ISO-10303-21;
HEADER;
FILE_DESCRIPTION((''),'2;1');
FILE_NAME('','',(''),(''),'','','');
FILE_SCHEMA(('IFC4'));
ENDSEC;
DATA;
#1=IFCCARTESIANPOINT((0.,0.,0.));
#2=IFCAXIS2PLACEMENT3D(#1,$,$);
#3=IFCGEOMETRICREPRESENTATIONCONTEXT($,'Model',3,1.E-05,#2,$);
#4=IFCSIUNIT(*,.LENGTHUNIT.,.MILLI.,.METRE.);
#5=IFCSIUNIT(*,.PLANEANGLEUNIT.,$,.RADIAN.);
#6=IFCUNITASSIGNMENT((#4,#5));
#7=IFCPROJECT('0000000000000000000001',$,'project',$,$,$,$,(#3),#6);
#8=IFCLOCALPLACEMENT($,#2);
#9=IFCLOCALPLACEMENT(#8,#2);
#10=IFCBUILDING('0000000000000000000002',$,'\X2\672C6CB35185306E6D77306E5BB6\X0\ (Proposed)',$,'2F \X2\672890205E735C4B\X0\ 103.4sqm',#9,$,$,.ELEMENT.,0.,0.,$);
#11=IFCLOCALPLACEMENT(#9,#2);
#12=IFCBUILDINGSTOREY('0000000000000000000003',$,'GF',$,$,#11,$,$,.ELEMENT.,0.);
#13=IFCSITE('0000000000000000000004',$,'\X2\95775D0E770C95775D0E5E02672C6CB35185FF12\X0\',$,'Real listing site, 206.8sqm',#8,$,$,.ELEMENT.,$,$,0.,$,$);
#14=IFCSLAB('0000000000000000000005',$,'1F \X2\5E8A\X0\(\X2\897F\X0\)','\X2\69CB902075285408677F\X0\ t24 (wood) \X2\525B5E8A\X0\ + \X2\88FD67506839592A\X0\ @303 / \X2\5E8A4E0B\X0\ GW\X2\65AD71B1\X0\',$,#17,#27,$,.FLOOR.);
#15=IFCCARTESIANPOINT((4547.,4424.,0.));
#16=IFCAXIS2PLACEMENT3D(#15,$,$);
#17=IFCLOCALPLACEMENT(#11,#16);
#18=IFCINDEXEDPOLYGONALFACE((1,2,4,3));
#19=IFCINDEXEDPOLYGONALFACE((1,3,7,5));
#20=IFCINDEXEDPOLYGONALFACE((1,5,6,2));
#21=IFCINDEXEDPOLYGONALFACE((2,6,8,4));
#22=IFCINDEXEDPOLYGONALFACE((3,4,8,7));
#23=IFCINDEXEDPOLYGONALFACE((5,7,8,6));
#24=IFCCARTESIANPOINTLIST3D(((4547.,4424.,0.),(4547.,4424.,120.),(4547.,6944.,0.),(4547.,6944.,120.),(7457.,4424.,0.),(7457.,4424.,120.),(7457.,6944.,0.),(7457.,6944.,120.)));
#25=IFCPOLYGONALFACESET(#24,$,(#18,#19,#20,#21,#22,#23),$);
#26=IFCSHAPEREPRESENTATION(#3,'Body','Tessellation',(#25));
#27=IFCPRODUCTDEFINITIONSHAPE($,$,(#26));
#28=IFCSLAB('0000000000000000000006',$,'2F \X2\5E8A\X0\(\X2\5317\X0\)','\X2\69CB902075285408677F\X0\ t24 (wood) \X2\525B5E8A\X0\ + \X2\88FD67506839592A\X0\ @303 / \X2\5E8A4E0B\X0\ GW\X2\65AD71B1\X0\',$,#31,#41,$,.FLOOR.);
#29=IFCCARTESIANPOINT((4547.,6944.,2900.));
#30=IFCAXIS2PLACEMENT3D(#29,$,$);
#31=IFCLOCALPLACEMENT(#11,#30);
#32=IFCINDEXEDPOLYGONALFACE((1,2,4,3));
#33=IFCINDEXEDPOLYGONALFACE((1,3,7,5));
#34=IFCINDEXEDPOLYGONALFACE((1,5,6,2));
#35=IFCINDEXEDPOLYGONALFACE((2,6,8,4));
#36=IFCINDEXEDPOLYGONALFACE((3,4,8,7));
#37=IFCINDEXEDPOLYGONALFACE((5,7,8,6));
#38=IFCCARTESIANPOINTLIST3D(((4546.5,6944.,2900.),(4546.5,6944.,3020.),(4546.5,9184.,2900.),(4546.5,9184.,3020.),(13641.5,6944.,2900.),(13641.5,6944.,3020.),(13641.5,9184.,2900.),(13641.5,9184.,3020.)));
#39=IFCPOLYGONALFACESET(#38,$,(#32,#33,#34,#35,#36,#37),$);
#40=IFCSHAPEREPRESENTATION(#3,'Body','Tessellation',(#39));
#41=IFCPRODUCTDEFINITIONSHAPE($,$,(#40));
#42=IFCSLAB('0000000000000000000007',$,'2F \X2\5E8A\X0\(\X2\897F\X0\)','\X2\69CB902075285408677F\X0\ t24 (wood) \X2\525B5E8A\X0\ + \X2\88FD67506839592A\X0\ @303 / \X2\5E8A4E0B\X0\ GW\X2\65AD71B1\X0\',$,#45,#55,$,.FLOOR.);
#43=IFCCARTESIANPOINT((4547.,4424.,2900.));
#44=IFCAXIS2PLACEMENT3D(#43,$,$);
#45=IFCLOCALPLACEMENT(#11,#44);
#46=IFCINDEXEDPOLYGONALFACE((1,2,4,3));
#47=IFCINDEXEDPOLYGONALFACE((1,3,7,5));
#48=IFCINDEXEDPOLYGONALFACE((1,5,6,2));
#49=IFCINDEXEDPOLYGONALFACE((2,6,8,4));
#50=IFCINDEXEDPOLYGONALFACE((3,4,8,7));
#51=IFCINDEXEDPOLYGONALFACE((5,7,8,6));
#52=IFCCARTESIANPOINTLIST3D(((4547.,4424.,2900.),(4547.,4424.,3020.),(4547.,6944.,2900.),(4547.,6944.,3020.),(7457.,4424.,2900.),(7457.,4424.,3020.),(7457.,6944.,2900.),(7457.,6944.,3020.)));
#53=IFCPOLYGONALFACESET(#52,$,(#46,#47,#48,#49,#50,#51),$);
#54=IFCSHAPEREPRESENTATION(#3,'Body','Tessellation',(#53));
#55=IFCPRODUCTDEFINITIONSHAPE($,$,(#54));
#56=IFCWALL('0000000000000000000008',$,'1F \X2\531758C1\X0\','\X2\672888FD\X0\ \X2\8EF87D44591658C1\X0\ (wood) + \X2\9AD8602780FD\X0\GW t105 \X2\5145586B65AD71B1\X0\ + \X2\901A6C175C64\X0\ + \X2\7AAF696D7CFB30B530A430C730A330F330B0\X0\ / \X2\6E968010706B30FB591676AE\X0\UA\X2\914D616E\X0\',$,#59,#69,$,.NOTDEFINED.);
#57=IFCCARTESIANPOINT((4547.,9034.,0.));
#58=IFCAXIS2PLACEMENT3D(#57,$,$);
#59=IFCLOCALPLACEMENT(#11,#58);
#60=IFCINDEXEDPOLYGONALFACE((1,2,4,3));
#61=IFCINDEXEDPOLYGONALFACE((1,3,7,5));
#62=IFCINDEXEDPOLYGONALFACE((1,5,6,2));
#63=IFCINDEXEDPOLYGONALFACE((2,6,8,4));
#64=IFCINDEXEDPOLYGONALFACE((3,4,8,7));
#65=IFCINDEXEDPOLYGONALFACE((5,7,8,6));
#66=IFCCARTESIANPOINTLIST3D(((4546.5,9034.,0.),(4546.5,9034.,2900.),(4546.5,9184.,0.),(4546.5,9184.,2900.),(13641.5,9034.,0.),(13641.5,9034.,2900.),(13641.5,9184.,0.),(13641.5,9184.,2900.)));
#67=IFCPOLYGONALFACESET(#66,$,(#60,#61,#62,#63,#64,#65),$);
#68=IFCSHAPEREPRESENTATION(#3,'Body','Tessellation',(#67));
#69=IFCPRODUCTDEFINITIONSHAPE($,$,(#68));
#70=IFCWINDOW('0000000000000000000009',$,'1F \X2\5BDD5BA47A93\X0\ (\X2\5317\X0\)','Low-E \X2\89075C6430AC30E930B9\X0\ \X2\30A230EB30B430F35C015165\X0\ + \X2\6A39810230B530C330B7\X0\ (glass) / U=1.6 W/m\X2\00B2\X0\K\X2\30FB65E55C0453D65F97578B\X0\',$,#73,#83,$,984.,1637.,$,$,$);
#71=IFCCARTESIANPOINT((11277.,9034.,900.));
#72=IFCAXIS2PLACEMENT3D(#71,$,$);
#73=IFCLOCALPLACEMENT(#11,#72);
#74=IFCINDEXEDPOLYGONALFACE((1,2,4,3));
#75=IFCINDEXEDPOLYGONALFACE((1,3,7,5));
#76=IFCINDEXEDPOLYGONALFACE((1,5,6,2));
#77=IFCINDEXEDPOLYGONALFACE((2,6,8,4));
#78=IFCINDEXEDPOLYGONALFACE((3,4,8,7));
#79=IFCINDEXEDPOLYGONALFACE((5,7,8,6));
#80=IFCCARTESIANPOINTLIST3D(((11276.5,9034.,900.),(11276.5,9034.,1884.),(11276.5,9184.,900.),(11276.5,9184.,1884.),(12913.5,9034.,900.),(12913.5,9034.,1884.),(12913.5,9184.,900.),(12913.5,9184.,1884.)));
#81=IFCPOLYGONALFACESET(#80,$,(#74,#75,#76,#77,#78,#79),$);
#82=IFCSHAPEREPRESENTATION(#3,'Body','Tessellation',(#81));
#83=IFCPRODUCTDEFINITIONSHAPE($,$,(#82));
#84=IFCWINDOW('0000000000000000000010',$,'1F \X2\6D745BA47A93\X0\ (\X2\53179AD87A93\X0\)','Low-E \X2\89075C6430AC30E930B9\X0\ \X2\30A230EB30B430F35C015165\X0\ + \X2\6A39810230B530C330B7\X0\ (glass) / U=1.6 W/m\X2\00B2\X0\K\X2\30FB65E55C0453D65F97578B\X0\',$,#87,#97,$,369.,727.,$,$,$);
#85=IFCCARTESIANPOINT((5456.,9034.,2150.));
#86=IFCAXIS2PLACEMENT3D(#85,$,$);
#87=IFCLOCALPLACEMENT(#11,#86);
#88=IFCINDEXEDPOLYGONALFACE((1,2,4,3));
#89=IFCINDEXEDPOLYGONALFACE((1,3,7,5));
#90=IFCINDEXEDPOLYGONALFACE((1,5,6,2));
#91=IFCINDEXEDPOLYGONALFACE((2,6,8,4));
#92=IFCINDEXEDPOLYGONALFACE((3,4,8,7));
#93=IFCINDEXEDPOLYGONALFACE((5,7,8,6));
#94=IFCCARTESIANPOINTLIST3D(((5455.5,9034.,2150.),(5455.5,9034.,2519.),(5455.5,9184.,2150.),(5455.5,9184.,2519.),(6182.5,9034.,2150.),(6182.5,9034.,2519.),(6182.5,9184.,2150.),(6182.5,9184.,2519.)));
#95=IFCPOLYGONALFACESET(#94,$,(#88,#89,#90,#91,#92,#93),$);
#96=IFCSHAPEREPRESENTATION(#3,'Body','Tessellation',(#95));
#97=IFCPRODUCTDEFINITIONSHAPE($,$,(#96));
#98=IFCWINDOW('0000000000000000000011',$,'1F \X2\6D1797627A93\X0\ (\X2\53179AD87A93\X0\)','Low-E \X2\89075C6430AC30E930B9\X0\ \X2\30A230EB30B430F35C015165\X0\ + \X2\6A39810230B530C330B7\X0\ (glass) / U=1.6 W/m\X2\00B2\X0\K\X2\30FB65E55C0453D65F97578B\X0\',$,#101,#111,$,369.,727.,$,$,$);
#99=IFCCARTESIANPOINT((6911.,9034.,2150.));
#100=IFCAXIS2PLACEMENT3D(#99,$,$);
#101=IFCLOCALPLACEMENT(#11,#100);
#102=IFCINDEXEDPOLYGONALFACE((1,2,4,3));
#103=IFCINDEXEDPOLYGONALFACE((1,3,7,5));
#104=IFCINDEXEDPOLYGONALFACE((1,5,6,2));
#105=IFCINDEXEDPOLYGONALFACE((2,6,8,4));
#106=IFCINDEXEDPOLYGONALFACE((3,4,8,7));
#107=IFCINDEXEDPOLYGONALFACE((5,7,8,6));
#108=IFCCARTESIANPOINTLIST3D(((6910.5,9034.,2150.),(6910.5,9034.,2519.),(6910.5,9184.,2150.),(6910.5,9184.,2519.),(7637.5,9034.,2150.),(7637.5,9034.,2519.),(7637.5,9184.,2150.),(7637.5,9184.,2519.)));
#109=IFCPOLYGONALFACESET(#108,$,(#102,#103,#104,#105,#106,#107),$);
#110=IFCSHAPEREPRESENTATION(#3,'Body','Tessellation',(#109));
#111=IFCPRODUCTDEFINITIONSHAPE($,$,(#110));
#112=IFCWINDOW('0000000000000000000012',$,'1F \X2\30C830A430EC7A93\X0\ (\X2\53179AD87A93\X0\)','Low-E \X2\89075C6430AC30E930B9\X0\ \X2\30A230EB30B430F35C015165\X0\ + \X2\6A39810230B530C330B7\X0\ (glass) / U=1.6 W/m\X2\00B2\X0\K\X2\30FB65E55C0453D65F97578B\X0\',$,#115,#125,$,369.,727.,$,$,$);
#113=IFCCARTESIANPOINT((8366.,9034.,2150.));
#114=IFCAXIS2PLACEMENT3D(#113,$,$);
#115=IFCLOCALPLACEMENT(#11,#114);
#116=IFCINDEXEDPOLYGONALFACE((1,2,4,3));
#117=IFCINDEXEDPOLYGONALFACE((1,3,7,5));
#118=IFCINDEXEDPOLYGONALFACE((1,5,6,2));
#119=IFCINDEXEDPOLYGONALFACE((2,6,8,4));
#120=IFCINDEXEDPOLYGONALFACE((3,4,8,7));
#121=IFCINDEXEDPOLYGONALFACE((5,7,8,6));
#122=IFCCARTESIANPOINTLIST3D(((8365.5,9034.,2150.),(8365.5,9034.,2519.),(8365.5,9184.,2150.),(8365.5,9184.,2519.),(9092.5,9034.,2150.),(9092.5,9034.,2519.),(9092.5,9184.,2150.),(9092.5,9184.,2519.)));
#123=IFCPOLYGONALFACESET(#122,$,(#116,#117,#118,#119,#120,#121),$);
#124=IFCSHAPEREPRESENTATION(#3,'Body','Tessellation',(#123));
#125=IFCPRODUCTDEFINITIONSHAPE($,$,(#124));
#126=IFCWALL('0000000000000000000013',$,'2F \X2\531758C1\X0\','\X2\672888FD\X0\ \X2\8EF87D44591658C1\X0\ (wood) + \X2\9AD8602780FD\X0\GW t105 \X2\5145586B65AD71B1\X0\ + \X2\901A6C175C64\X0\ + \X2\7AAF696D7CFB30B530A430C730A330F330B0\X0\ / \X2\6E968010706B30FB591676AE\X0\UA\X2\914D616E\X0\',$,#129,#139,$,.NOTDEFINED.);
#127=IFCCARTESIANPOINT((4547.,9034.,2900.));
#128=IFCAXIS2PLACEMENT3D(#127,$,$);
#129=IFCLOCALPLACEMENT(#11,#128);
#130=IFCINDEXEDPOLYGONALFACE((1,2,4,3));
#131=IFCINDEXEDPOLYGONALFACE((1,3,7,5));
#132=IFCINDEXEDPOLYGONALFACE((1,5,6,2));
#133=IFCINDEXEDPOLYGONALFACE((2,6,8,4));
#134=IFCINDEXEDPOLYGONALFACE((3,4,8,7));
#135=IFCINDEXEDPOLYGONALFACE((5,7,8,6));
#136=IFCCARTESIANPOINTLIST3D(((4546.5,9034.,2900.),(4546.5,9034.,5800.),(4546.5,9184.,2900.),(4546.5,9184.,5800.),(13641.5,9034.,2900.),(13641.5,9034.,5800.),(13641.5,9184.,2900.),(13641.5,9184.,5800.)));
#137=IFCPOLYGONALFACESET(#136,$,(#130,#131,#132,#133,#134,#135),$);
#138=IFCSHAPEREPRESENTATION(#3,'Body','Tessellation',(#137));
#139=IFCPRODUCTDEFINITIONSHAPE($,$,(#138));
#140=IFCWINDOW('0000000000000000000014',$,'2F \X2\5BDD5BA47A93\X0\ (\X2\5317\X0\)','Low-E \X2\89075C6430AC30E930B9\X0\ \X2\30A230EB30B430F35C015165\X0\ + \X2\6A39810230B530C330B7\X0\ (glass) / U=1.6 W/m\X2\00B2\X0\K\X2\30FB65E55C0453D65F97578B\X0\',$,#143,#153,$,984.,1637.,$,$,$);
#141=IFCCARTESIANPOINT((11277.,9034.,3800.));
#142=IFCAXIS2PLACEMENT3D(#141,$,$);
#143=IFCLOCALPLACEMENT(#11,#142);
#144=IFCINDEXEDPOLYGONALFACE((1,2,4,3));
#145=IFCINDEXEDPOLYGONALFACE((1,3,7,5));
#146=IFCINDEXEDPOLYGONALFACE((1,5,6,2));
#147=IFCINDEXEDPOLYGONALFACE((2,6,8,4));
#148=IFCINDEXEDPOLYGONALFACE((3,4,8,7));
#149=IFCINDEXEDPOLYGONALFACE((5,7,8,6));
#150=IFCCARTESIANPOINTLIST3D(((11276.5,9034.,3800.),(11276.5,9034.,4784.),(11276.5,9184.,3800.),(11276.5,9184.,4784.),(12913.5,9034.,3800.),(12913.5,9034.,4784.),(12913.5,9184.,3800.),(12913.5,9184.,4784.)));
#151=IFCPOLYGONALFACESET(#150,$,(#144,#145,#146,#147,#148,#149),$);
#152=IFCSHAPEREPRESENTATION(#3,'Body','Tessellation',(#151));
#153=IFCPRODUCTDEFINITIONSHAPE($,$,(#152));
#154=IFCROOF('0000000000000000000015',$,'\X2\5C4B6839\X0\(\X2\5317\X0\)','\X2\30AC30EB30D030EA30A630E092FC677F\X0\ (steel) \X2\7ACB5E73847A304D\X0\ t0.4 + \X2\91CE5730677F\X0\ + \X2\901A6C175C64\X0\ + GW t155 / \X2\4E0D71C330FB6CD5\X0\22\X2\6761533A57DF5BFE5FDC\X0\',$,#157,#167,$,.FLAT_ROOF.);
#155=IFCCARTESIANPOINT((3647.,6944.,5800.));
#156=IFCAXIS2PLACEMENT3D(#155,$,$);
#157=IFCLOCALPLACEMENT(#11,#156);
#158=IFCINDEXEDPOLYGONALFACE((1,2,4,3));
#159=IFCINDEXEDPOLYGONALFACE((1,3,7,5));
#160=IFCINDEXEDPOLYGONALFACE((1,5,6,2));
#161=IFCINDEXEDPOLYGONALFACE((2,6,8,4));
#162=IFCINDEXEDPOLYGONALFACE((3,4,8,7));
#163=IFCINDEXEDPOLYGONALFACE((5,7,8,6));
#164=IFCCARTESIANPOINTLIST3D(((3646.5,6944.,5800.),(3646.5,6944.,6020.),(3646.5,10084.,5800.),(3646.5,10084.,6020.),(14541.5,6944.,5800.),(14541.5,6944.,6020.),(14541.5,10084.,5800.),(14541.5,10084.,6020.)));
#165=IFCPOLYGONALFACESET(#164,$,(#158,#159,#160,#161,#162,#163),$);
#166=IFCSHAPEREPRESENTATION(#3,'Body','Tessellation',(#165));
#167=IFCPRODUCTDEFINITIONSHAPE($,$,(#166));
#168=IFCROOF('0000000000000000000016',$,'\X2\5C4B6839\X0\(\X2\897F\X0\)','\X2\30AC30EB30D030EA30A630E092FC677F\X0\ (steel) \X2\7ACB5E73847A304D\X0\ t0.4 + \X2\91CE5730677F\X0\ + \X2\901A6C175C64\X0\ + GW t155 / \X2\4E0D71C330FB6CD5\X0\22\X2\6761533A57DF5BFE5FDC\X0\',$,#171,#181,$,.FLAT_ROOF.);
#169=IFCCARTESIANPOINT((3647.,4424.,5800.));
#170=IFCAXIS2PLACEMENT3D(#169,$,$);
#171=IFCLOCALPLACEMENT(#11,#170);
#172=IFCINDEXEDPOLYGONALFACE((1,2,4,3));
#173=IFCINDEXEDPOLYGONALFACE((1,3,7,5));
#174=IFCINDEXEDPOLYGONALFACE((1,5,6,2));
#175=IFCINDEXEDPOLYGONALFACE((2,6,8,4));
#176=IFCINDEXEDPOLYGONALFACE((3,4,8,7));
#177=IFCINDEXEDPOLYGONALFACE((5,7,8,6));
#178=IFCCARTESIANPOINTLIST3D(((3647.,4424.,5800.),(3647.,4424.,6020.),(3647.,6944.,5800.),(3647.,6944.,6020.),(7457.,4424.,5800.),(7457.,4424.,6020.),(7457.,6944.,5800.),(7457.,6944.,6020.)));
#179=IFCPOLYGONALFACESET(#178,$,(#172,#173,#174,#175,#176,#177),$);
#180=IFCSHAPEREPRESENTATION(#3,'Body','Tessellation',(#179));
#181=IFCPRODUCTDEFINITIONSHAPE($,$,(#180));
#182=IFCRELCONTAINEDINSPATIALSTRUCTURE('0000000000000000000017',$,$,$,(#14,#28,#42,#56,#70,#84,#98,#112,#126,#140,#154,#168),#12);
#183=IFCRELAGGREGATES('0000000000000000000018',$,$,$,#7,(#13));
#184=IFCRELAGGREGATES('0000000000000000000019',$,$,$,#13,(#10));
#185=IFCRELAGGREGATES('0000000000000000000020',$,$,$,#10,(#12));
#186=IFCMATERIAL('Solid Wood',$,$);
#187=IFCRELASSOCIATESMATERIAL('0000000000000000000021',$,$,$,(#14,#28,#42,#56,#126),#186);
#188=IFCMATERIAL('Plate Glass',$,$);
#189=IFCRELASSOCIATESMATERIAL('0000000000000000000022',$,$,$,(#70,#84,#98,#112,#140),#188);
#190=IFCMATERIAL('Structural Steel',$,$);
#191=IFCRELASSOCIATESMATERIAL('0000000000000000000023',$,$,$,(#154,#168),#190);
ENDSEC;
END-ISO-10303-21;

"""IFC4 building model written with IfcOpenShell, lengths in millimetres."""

from ifc_helpers import new_model, si_unit, frame, frame_2d, origin, place, context, project, spatial, rectangle, extrude, material, element, fill, save


model = new_model("IFC4")

# Units and contexts
model_context = context("Model", 3, precision=1e-05, world=origin())
ifc_project = project(units=[si_unit("LENGTHUNIT", "METRE", prefix="MILLI"), si_unit("PLANEANGLEUNIT", "RADIAN")], contexts=[model_context])

# Site, building, storey
site_placement = place(None, origin())
site = spatial("IfcSite", under=ifc_project, at=site_placement, Name="長崎県長崎市本河内２", ObjectType="Real listing site, 206.8sqm", CompositionType="ELEMENT", RefElevation=0.0)
building_placement = place(site_placement, origin())
building = spatial("IfcBuilding", under=site, at=building_placement, Name="本河内の海の家 (Proposed)", ObjectType="2F 木造平屋 103.4sqm", CompositionType="ELEMENT", ElevationOfRefHeight=0.0, ElevationOfTerrain=0.0)
storey_placement = place(building_placement, origin())
storey = spatial("IfcBuildingStorey", under=building, at=storey_placement, Name="GF", CompositionType="ELEMENT", Elevation=0.0)

# Slabs
ifc_material_1 = material(Name="Solid Wood")
slab_1_placement = place(storey_placement, frame((4547.0, 4424.0, 0.0)))
element("IfcSlab", 1, at=slab_1_placement, inside=storey, material=ifc_material_1, Name="1F 床(西)", Description="構造用合板 t24 (wood) 剛床 + 製材根太 @303 / 床下 GW断熱", PredefinedType="FLOOR", context=model_context, shape_type="SweptSolid", body=[
    extrude(rectangle(XDim=2910.0, YDim=2520.0, at=frame_2d((1455.0, 1260.0))), frame((4547.0, 4424.0, 0.0)), (0.0, 0.0, 1.0), 120.0),
])
slab_2_placement = place(storey_placement, frame((4547.0, 6944.0, 2900.0)))
element("IfcSlab", 2, at=slab_2_placement, inside=storey, material=ifc_material_1, Name="2F 床(北)", Description="構造用合板 t24 (wood) 剛床 + 製材根太 @303 / 床下 GW断熱", PredefinedType="FLOOR", context=model_context, shape_type="SweptSolid", body=[
    extrude(rectangle(XDim=9095.0, YDim=2240.0, at=frame_2d((4547.0, 1120.0))), frame((4547.0, 6944.0, 2900.0)), (0.0, 0.0, 1.0), 120.0),
])
slab_3_placement = place(storey_placement, frame((4547.0, 4424.0, 2900.0)))
element("IfcSlab", 3, at=slab_3_placement, inside=storey, material=ifc_material_1, Name="2F 床(西)", Description="構造用合板 t24 (wood) 剛床 + 製材根太 @303 / 床下 GW断熱", PredefinedType="FLOOR", context=model_context, shape_type="SweptSolid", body=[
    extrude(rectangle(XDim=2910.0, YDim=2520.0, at=frame_2d((1455.0, 1260.0))), frame((4547.0, 4424.0, 2900.0)), (0.0, 0.0, 1.0), 120.0),
])

# Wall, openings, windows
wall_1_placement = place(storey_placement, frame((4547.0, 9034.0, 0.0)))
wall_1 = element("IfcWall", 4, at=wall_1_placement, inside=storey, material=ifc_material_1, Name="1F 北壁", Description="木製 軸組外壁 (wood) + 高性能GW t105 充填断熱 + 通気層 + 窯業系サイディング / 準耐火・外皮UA配慮", PredefinedType="NOTDEFINED", context=model_context, shape_type="SweptSolid", body=[
    extrude(rectangle(XDim=9095.0, YDim=150.0, at=frame_2d((4547.0, 75.0))), frame((4547.0, 9034.0, 0.0)), (0.0, 0.0, 1.0), 2900.0),
])
opening_1_placement = place(storey_placement, frame((11277.0, 9034.0, 900.0)))
opening_1 = element("IfcOpeningElement", 5, at=opening_1_placement, cuts=wall_1, PredefinedType="NOTDEFINED", context=model_context, shape_type="SweptSolid", body=[
    extrude(rectangle(XDim=1637.0, YDim=150.0, at=frame_2d((818.0, 75.0))), frame((11277.0, 9034.0, 900.0)), (0.0, 0.0, 1.0), 984.0),
])
opening_2_placement = place(storey_placement, frame((5456.0, 9034.0, 2150.0)))
opening_2 = element("IfcOpeningElement", 6, at=opening_2_placement, cuts=wall_1, PredefinedType="NOTDEFINED", context=model_context, shape_type="SweptSolid", body=[
    extrude(rectangle(XDim=727.0, YDim=150.0, at=frame_2d((363.0, 75.0))), frame((5456.0, 9034.0, 2150.0)), (0.0, 0.0, 1.0), 369.0),
])
opening_3_placement = place(storey_placement, frame((6911.0, 9034.0, 2150.0)))
opening_3 = element("IfcOpeningElement", 7, at=opening_3_placement, cuts=wall_1, PredefinedType="NOTDEFINED", context=model_context, shape_type="SweptSolid", body=[
    extrude(rectangle(XDim=727.0, YDim=150.0, at=frame_2d((363.0, 75.0))), frame((6911.0, 9034.0, 2150.0)), (0.0, 0.0, 1.0), 369.0),
])
opening_4_placement = place(storey_placement, frame((8366.0, 9034.0, 2150.0)))
opening_4 = element("IfcOpeningElement", 8, at=opening_4_placement, cuts=wall_1, PredefinedType="NOTDEFINED", context=model_context, shape_type="SweptSolid", body=[
    extrude(rectangle(XDim=727.0, YDim=150.0, at=frame_2d((363.0, 75.0))), frame((8366.0, 9034.0, 2150.0)), (0.0, 0.0, 1.0), 369.0),
])
ifc_material_2 = material(Name="Plate Glass")
window_1_placement = place(storey_placement, frame((11277.0, 9034.0, 900.0)))
window_1 = element("IfcWindow", 9, at=window_1_placement, inside=storey, material=ifc_material_2, Name="1F 寝室窓 (北)", Description="Low-E 複層ガラス アルゴン封入 + 樹脂サッシ (glass) / U=1.6 W/m²K・日射取得型", OverallHeight=984.0, OverallWidth=1637.0, context=model_context, shape_type="SweptSolid", body=[
    extrude(rectangle(XDim=1637.0, YDim=150.0, at=frame_2d((818.0, 75.0))), frame((11277.0, 9034.0, 900.0)), (0.0, 0.0, 1.0), 984.0),
])
fill(opening_1, window_1)
window_2_placement = place(storey_placement, frame((5456.0, 9034.0, 2150.0)))
window_2 = element("IfcWindow", 10, at=window_2_placement, inside=storey, material=ifc_material_2, Name="1F 浴室窓 (北高窓)", Description="Low-E 複層ガラス アルゴン封入 + 樹脂サッシ (glass) / U=1.6 W/m²K・日射取得型", OverallHeight=369.0, OverallWidth=727.0, context=model_context, shape_type="SweptSolid", body=[
    extrude(rectangle(XDim=727.0, YDim=150.0, at=frame_2d((363.0, 75.0))), frame((5456.0, 9034.0, 2150.0)), (0.0, 0.0, 1.0), 369.0),
])
fill(opening_2, window_2)
window_3_placement = place(storey_placement, frame((6911.0, 9034.0, 2150.0)))
window_3 = element("IfcWindow", 11, at=window_3_placement, inside=storey, material=ifc_material_2, Name="1F 洗面窓 (北高窓)", Description="Low-E 複層ガラス アルゴン封入 + 樹脂サッシ (glass) / U=1.6 W/m²K・日射取得型", OverallHeight=369.0, OverallWidth=727.0, context=model_context, shape_type="SweptSolid", body=[
    extrude(rectangle(XDim=727.0, YDim=150.0, at=frame_2d((363.0, 75.0))), frame((6911.0, 9034.0, 2150.0)), (0.0, 0.0, 1.0), 369.0),
])
fill(opening_3, window_3)
window_4_placement = place(storey_placement, frame((8366.0, 9034.0, 2150.0)))
window_4 = element("IfcWindow", 12, at=window_4_placement, inside=storey, material=ifc_material_2, Name="1F トイレ窓 (北高窓)", Description="Low-E 複層ガラス アルゴン封入 + 樹脂サッシ (glass) / U=1.6 W/m²K・日射取得型", OverallHeight=369.0, OverallWidth=727.0, context=model_context, shape_type="SweptSolid", body=[
    extrude(rectangle(XDim=727.0, YDim=150.0, at=frame_2d((363.0, 75.0))), frame((8366.0, 9034.0, 2150.0)), (0.0, 0.0, 1.0), 369.0),
])
fill(opening_4, window_4)

# Wall, opening, window
wall_2_placement = place(storey_placement, frame((4547.0, 9034.0, 2900.0)))
wall_2 = element("IfcWall", 13, at=wall_2_placement, inside=storey, material=ifc_material_1, Name="2F 北壁", Description="木製 軸組外壁 (wood) + 高性能GW t105 充填断熱 + 通気層 + 窯業系サイディング / 準耐火・外皮UA配慮", PredefinedType="NOTDEFINED", context=model_context, shape_type="SweptSolid", body=[
    extrude(rectangle(XDim=9095.0, YDim=150.0, at=frame_2d((4547.0, 75.0))), frame((4547.0, 9034.0, 2900.0)), (0.0, 0.0, 1.0), 2900.0),
])
opening_5_placement = place(storey_placement, frame((11277.0, 9034.0, 3800.0)))
opening_5 = element("IfcOpeningElement", 14, at=opening_5_placement, cuts=wall_2, PredefinedType="NOTDEFINED", context=model_context, shape_type="SweptSolid", body=[
    extrude(rectangle(XDim=1637.0, YDim=150.0, at=frame_2d((818.0, 75.0))), frame((11277.0, 9034.0, 3800.0)), (0.0, 0.0, 1.0), 984.0),
])
window_5_placement = place(storey_placement, frame((11277.0, 9034.0, 3800.0)))
window_5 = element("IfcWindow", 15, at=window_5_placement, inside=storey, material=ifc_material_2, Name="2F 寝室窓 (北)", Description="Low-E 複層ガラス アルゴン封入 + 樹脂サッシ (glass) / U=1.6 W/m²K・日射取得型", OverallHeight=984.0, OverallWidth=1637.0, context=model_context, shape_type="SweptSolid", body=[
    extrude(rectangle(XDim=1637.0, YDim=150.0, at=frame_2d((818.0, 75.0))), frame((11277.0, 9034.0, 3800.0)), (0.0, 0.0, 1.0), 984.0),
])
fill(opening_5, window_5)

# Roofs
ifc_material_3 = material(Name="Structural Steel")
for number, where, name in (
    (16, (3647.0, 6944.0, 5800.0), "屋根(北)"),
):
    element("IfcRoof", number, at=place(storey_placement, frame(where)), inside=storey, material=ifc_material_3, Name=name, Description="ガルバリウム鋼板 (steel) 立平葺き t0.4 + 野地板 + 通気層 + GW t155 / 不燃・法22条区域対応", PredefinedType="FLAT_ROOF", context=model_context, shape_type="SweptSolid", body=[
        extrude(rectangle(XDim=10895.0, YDim=3140.0, at=frame_2d((5447.0, 1570.0))), frame((3647.0, 6944.0, 5800.0)), (0.0, 0.0, 1.0), 220.0),
    ])
roof_placement = place(storey_placement, frame((3647.0, 4424.0, 5800.0)))
element("IfcRoof", 17, at=roof_placement, inside=storey, material=ifc_material_3, Name="屋根(西)", Description="ガルバリウム鋼板 (steel) 立平葺き t0.4 + 野地板 + 通気層 + GW t155 / 不燃・法22条区域対応", PredefinedType="FLAT_ROOF", context=model_context, shape_type="SweptSolid", body=[
    extrude(rectangle(XDim=3810.0, YDim=2520.0, at=frame_2d((1905.0, 1260.0))), frame((3647.0, 4424.0, 5800.0)), (0.0, 0.0, 1.0), 220.0),
])

save(model, "model.ifc")
